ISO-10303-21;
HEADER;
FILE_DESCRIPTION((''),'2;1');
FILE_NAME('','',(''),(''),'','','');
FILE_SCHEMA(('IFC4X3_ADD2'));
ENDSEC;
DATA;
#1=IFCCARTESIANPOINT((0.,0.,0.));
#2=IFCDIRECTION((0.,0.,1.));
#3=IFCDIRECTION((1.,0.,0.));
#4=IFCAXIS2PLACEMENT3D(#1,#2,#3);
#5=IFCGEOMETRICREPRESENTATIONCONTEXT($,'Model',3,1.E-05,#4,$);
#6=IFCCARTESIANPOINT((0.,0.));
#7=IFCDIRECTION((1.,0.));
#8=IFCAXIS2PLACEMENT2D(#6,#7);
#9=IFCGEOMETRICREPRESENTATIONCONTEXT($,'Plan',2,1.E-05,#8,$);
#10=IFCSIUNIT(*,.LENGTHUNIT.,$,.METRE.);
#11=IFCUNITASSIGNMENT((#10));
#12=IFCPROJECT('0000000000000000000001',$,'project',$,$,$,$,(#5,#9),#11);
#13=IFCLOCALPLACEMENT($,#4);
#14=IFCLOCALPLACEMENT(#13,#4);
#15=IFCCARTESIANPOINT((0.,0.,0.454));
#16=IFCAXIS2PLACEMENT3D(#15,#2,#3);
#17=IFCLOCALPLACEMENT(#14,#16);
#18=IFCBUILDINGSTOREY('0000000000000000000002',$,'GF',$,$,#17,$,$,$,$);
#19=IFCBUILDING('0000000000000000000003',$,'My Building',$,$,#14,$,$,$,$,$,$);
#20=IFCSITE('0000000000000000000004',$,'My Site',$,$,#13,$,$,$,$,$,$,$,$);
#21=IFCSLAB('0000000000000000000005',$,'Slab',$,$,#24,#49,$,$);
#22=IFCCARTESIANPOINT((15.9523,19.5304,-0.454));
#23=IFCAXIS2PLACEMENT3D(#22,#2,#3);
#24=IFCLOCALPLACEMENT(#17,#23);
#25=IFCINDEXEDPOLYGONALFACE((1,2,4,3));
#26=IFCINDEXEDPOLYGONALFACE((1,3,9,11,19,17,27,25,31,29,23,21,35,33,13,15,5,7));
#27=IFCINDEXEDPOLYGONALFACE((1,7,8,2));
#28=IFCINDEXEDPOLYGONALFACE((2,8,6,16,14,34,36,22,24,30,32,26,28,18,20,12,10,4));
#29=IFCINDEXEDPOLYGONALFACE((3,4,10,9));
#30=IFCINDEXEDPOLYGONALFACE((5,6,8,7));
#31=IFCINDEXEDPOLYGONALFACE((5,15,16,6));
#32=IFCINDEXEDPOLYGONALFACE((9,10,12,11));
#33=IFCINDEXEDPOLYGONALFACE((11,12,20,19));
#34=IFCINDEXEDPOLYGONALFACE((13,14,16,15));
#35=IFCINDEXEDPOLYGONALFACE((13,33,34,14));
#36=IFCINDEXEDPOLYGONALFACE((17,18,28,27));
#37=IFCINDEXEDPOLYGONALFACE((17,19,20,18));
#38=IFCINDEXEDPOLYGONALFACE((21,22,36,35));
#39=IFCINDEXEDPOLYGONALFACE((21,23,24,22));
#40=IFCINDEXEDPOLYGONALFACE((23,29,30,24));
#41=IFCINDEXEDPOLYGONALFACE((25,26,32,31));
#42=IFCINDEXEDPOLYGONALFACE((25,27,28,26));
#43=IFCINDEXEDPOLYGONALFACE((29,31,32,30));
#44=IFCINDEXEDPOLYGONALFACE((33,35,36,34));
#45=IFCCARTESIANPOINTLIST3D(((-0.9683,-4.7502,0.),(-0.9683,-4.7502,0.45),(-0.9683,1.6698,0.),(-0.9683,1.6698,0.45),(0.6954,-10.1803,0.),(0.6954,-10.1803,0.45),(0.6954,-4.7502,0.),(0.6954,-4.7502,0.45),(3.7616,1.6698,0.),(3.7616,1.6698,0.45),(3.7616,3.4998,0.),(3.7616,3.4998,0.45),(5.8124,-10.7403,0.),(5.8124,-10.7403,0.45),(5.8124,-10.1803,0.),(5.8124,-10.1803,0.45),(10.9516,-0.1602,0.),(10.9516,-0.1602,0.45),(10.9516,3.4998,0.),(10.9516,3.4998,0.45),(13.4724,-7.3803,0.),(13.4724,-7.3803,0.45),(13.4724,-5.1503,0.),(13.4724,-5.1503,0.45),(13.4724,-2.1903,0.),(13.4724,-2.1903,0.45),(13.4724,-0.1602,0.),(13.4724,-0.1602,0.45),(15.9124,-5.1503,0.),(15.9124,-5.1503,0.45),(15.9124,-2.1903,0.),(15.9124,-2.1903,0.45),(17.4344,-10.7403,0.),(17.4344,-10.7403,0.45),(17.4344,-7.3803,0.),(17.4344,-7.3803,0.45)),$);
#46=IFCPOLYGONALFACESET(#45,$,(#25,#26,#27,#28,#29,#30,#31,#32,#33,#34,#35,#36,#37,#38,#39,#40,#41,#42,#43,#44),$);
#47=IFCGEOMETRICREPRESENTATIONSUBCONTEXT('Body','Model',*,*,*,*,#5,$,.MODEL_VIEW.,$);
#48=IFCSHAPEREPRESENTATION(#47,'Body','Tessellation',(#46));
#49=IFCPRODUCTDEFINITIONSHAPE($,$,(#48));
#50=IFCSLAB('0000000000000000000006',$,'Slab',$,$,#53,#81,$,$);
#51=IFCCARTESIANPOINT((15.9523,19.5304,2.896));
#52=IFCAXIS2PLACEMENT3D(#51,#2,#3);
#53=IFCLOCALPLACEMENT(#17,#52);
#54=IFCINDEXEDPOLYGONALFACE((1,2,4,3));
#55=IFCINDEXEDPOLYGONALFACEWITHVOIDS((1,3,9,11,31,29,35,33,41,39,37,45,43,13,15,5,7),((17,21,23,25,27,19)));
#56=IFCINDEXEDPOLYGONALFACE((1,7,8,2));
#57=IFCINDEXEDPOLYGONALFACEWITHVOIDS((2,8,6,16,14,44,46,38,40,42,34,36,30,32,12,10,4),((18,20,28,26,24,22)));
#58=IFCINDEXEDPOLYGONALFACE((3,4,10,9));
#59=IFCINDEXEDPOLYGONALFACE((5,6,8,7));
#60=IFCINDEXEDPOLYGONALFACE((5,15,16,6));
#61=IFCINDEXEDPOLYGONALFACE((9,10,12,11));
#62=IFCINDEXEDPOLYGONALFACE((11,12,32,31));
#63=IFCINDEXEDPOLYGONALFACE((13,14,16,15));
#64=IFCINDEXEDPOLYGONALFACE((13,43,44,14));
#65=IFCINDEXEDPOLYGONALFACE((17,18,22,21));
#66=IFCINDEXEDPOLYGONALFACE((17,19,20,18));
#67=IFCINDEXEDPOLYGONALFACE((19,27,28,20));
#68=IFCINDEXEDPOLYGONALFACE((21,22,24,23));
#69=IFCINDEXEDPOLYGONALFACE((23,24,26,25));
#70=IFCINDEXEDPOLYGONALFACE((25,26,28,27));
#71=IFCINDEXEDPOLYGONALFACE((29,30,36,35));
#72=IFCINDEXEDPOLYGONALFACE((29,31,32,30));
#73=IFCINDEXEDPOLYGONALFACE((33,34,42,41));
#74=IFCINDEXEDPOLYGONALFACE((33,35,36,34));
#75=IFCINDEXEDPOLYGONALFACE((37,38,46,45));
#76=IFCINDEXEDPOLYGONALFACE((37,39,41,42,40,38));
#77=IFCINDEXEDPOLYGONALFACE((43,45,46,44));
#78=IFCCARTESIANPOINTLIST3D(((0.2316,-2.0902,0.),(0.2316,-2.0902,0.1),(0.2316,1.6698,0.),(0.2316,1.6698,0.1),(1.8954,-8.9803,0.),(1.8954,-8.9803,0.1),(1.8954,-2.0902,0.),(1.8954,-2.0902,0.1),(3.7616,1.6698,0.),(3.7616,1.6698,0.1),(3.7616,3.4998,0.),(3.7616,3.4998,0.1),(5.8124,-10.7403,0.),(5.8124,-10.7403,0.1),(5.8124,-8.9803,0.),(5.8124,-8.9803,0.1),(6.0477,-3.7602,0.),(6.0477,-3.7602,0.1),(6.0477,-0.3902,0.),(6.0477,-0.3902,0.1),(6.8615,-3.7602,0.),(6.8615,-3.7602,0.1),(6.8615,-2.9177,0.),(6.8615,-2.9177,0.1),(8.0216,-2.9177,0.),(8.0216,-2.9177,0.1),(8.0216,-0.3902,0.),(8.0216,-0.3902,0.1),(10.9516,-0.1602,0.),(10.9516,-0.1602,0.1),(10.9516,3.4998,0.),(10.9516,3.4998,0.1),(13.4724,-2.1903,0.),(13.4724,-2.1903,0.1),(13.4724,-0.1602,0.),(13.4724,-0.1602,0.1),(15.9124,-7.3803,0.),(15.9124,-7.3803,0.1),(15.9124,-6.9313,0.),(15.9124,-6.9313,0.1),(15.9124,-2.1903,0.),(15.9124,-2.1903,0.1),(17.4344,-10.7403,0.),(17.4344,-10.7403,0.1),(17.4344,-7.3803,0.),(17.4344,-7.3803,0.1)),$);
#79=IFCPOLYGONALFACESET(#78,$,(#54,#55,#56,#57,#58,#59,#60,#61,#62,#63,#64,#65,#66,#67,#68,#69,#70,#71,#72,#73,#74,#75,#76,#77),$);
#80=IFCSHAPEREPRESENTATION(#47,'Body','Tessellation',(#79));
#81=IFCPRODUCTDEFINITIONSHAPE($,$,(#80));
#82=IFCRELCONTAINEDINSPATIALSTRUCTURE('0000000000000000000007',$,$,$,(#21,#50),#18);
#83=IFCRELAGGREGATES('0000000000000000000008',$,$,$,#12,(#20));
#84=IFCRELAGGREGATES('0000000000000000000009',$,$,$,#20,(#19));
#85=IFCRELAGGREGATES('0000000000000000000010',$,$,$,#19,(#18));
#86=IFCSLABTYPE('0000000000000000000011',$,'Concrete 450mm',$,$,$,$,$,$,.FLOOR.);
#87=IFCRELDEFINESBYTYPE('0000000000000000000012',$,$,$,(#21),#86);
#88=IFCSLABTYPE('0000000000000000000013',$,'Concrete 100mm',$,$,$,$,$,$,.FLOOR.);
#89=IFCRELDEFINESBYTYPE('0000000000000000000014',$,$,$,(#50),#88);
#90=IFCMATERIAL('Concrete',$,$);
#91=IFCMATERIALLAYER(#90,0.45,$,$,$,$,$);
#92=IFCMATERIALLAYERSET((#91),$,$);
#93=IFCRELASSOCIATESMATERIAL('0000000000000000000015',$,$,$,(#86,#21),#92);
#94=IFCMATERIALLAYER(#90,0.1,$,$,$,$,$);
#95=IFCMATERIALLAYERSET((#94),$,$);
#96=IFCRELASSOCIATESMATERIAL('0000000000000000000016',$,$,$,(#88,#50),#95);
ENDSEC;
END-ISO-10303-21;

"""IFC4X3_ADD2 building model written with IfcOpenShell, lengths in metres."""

from ifc_helpers import new_model, si_unit, frame, origin_with_axes, origin_2d_with_axis, place, context, subcontext, project, spatial, line, indexed_curve, outline, extrude, material, layer, layer_set, layer_usage, type_object, element, save


model = new_model("IFC4X3_ADD2")

# Units and contexts
model_context = context("Model", 3, precision=1e-05, world=origin_with_axes())
plan_context = context("Plan", 2, precision=1e-05, world=origin_2d_with_axis())
body_context = subcontext(model_context, "Body", "Model", "MODEL_VIEW")
ifc_project = project(units=[si_unit("LENGTHUNIT", "METRE")], contexts=[model_context, plan_context])

# Site, building, storey
site_placement = place(None, origin_with_axes())
site = spatial("IfcSite", under=ifc_project, at=site_placement, Name="My Site")
building_placement = place(site_placement, origin_with_axes())
building = spatial("IfcBuilding", under=site, at=building_placement, Name="My Building")
storey_placement = place(building_placement, frame((0.0, 0.0, 0.454), z_axis=(0.0, 0.0, 1.0), x_axis=(1.0, 0.0, 0.0)))
storey = spatial("IfcBuildingStorey", under=building, at=storey_placement, Name="GF")

# Slabs
ifc_material_1 = material(Name="Concrete")
ifc_layer_1 = layer(ifc_material_1, 0.45)
ifc_layer_set_1 = layer_set([ifc_layer_1])
ifc_layer_usage_1 = layer_usage(ifc_layer_set_1, "AXIS3", "POSITIVE", 0.0)
slab_type_1 = type_object("IfcSlabType", Name="Concrete 450mm", PredefinedType="FLOOR", material=ifc_layer_set_1)
slab_1_placement = place(storey_placement, frame((15.9523, 19.5304, -0.454), z_axis=(0.0, 0.0, 1.0), x_axis=(1.0, 0.0, 0.0)))
element("IfcSlab", 1, at=slab_1_placement, inside=storey, type_object=slab_type_1, material=ifc_layer_usage_1, Name="Slab", context=body_context, shape_type="SweptSolid", body=[
    extrude(outline(indexed_curve([(0.6954, -4.7502), (-0.9683, -4.7502), (-0.9683, 1.6698), (3.7616, 1.6698), (3.7616, 3.4998), (10.9516, 3.4998), (10.9516, -0.1602), (13.4724, -0.1602), (13.4724, -2.1903), (15.9124, -2.1903), (15.9124, -5.1503), (13.4724, -5.1503), (13.4724, -7.3803), (17.4344, -7.3803), (17.4344, -10.7403), (5.8124, -10.7403), (5.8124, -10.1803), (0.6954, -10.1803)], segments=[line(5, 4), line(4, 3), line(3, 2), line(2, 1), line(1, 18), line(18, 17), line(17, 16), line(16, 15), line(15, 14), line(14, 13), line(13, 12), line(12, 11), line(11, 10), line(10, 9), line(9, 8), line(8, 7), line(7, 6), line(6, 5)], self_intersect=False)), None, (0.0, 0.0, 1.0), 0.45),
])
ifc_layer_2 = layer(ifc_material_1, 0.1)
ifc_layer_set_2 = layer_set([ifc_layer_2])
ifc_layer_usage_2 = layer_usage(ifc_layer_set_2, "AXIS3", "POSITIVE", 0.0)
slab_type_2 = type_object("IfcSlabType", Name="Concrete 100mm", PredefinedType="FLOOR", material=ifc_layer_set_2)
slab_2_placement = place(storey_placement, frame((15.9523, 19.5304, 2.896), z_axis=(0.0, 0.0, 1.0), x_axis=(1.0, 0.0, 0.0)))
element("IfcSlab", 2, at=slab_2_placement, inside=storey, type_object=slab_type_2, material=ifc_layer_usage_2, Name="Slab", context=body_context, shape_type="SweptSolid", body=[
    extrude(outline(indexed_curve([(1.8954, -8.9803), (1.8954, -2.0902), (0.2316, -2.0902), (0.2316, 1.6698), (3.7616, 1.6698), (3.7616, 3.4998), (10.9516, 3.4998), (10.9516, -0.1602), (13.4724, -0.1602), (13.4724, -2.1903), (15.9124, -2.1903), (15.9124, -6.9313), (15.9124, -7.3803), (17.4344, -7.3803), (17.4344, -10.7403), (5.8124, -10.7403), (5.8124, -8.9803), (6.0477, -3.7602), (6.8615, -3.7602), (6.8615, -2.9177), (8.0216, -2.9177), (8.0216, -0.3902), (6.0477, -0.3902)], segments=[line(15, 14), line(14, 13), line(13, 12), line(12, 11), line(11, 10), line(10, 9), line(9, 8), line(8, 7), line(7, 6), line(6, 5), line(5, 4), line(4, 3), line(3, 2), line(2, 1), line(1, 17), line(17, 16), line(16, 15)], self_intersect=False), holes=[indexed_curve([(1.8954, -8.9803), (1.8954, -2.0902), (0.2316, -2.0902), (0.2316, 1.6698), (3.7616, 1.6698), (3.7616, 3.4998), (10.9516, 3.4998), (10.9516, -0.1602), (13.4724, -0.1602), (13.4724, -2.1903), (15.9124, -2.1903), (15.9124, -6.9313), (15.9124, -7.3803), (17.4344, -7.3803), (17.4344, -10.7403), (5.8124, -10.7403), (5.8124, -8.9803), (6.0477, -3.7602), (6.8615, -3.7602), (6.8615, -2.9177), (8.0216, -2.9177), (8.0216, -0.3902), (6.0477, -0.3902)], segments=[line(19, 18), line(18, 23), line(23, 22), line(22, 21), line(21, 20), line(20, 19)], self_intersect=False)]), None, (0.0, 0.0, 1.0), 0.1),
])

save(model, "model.ifc")
